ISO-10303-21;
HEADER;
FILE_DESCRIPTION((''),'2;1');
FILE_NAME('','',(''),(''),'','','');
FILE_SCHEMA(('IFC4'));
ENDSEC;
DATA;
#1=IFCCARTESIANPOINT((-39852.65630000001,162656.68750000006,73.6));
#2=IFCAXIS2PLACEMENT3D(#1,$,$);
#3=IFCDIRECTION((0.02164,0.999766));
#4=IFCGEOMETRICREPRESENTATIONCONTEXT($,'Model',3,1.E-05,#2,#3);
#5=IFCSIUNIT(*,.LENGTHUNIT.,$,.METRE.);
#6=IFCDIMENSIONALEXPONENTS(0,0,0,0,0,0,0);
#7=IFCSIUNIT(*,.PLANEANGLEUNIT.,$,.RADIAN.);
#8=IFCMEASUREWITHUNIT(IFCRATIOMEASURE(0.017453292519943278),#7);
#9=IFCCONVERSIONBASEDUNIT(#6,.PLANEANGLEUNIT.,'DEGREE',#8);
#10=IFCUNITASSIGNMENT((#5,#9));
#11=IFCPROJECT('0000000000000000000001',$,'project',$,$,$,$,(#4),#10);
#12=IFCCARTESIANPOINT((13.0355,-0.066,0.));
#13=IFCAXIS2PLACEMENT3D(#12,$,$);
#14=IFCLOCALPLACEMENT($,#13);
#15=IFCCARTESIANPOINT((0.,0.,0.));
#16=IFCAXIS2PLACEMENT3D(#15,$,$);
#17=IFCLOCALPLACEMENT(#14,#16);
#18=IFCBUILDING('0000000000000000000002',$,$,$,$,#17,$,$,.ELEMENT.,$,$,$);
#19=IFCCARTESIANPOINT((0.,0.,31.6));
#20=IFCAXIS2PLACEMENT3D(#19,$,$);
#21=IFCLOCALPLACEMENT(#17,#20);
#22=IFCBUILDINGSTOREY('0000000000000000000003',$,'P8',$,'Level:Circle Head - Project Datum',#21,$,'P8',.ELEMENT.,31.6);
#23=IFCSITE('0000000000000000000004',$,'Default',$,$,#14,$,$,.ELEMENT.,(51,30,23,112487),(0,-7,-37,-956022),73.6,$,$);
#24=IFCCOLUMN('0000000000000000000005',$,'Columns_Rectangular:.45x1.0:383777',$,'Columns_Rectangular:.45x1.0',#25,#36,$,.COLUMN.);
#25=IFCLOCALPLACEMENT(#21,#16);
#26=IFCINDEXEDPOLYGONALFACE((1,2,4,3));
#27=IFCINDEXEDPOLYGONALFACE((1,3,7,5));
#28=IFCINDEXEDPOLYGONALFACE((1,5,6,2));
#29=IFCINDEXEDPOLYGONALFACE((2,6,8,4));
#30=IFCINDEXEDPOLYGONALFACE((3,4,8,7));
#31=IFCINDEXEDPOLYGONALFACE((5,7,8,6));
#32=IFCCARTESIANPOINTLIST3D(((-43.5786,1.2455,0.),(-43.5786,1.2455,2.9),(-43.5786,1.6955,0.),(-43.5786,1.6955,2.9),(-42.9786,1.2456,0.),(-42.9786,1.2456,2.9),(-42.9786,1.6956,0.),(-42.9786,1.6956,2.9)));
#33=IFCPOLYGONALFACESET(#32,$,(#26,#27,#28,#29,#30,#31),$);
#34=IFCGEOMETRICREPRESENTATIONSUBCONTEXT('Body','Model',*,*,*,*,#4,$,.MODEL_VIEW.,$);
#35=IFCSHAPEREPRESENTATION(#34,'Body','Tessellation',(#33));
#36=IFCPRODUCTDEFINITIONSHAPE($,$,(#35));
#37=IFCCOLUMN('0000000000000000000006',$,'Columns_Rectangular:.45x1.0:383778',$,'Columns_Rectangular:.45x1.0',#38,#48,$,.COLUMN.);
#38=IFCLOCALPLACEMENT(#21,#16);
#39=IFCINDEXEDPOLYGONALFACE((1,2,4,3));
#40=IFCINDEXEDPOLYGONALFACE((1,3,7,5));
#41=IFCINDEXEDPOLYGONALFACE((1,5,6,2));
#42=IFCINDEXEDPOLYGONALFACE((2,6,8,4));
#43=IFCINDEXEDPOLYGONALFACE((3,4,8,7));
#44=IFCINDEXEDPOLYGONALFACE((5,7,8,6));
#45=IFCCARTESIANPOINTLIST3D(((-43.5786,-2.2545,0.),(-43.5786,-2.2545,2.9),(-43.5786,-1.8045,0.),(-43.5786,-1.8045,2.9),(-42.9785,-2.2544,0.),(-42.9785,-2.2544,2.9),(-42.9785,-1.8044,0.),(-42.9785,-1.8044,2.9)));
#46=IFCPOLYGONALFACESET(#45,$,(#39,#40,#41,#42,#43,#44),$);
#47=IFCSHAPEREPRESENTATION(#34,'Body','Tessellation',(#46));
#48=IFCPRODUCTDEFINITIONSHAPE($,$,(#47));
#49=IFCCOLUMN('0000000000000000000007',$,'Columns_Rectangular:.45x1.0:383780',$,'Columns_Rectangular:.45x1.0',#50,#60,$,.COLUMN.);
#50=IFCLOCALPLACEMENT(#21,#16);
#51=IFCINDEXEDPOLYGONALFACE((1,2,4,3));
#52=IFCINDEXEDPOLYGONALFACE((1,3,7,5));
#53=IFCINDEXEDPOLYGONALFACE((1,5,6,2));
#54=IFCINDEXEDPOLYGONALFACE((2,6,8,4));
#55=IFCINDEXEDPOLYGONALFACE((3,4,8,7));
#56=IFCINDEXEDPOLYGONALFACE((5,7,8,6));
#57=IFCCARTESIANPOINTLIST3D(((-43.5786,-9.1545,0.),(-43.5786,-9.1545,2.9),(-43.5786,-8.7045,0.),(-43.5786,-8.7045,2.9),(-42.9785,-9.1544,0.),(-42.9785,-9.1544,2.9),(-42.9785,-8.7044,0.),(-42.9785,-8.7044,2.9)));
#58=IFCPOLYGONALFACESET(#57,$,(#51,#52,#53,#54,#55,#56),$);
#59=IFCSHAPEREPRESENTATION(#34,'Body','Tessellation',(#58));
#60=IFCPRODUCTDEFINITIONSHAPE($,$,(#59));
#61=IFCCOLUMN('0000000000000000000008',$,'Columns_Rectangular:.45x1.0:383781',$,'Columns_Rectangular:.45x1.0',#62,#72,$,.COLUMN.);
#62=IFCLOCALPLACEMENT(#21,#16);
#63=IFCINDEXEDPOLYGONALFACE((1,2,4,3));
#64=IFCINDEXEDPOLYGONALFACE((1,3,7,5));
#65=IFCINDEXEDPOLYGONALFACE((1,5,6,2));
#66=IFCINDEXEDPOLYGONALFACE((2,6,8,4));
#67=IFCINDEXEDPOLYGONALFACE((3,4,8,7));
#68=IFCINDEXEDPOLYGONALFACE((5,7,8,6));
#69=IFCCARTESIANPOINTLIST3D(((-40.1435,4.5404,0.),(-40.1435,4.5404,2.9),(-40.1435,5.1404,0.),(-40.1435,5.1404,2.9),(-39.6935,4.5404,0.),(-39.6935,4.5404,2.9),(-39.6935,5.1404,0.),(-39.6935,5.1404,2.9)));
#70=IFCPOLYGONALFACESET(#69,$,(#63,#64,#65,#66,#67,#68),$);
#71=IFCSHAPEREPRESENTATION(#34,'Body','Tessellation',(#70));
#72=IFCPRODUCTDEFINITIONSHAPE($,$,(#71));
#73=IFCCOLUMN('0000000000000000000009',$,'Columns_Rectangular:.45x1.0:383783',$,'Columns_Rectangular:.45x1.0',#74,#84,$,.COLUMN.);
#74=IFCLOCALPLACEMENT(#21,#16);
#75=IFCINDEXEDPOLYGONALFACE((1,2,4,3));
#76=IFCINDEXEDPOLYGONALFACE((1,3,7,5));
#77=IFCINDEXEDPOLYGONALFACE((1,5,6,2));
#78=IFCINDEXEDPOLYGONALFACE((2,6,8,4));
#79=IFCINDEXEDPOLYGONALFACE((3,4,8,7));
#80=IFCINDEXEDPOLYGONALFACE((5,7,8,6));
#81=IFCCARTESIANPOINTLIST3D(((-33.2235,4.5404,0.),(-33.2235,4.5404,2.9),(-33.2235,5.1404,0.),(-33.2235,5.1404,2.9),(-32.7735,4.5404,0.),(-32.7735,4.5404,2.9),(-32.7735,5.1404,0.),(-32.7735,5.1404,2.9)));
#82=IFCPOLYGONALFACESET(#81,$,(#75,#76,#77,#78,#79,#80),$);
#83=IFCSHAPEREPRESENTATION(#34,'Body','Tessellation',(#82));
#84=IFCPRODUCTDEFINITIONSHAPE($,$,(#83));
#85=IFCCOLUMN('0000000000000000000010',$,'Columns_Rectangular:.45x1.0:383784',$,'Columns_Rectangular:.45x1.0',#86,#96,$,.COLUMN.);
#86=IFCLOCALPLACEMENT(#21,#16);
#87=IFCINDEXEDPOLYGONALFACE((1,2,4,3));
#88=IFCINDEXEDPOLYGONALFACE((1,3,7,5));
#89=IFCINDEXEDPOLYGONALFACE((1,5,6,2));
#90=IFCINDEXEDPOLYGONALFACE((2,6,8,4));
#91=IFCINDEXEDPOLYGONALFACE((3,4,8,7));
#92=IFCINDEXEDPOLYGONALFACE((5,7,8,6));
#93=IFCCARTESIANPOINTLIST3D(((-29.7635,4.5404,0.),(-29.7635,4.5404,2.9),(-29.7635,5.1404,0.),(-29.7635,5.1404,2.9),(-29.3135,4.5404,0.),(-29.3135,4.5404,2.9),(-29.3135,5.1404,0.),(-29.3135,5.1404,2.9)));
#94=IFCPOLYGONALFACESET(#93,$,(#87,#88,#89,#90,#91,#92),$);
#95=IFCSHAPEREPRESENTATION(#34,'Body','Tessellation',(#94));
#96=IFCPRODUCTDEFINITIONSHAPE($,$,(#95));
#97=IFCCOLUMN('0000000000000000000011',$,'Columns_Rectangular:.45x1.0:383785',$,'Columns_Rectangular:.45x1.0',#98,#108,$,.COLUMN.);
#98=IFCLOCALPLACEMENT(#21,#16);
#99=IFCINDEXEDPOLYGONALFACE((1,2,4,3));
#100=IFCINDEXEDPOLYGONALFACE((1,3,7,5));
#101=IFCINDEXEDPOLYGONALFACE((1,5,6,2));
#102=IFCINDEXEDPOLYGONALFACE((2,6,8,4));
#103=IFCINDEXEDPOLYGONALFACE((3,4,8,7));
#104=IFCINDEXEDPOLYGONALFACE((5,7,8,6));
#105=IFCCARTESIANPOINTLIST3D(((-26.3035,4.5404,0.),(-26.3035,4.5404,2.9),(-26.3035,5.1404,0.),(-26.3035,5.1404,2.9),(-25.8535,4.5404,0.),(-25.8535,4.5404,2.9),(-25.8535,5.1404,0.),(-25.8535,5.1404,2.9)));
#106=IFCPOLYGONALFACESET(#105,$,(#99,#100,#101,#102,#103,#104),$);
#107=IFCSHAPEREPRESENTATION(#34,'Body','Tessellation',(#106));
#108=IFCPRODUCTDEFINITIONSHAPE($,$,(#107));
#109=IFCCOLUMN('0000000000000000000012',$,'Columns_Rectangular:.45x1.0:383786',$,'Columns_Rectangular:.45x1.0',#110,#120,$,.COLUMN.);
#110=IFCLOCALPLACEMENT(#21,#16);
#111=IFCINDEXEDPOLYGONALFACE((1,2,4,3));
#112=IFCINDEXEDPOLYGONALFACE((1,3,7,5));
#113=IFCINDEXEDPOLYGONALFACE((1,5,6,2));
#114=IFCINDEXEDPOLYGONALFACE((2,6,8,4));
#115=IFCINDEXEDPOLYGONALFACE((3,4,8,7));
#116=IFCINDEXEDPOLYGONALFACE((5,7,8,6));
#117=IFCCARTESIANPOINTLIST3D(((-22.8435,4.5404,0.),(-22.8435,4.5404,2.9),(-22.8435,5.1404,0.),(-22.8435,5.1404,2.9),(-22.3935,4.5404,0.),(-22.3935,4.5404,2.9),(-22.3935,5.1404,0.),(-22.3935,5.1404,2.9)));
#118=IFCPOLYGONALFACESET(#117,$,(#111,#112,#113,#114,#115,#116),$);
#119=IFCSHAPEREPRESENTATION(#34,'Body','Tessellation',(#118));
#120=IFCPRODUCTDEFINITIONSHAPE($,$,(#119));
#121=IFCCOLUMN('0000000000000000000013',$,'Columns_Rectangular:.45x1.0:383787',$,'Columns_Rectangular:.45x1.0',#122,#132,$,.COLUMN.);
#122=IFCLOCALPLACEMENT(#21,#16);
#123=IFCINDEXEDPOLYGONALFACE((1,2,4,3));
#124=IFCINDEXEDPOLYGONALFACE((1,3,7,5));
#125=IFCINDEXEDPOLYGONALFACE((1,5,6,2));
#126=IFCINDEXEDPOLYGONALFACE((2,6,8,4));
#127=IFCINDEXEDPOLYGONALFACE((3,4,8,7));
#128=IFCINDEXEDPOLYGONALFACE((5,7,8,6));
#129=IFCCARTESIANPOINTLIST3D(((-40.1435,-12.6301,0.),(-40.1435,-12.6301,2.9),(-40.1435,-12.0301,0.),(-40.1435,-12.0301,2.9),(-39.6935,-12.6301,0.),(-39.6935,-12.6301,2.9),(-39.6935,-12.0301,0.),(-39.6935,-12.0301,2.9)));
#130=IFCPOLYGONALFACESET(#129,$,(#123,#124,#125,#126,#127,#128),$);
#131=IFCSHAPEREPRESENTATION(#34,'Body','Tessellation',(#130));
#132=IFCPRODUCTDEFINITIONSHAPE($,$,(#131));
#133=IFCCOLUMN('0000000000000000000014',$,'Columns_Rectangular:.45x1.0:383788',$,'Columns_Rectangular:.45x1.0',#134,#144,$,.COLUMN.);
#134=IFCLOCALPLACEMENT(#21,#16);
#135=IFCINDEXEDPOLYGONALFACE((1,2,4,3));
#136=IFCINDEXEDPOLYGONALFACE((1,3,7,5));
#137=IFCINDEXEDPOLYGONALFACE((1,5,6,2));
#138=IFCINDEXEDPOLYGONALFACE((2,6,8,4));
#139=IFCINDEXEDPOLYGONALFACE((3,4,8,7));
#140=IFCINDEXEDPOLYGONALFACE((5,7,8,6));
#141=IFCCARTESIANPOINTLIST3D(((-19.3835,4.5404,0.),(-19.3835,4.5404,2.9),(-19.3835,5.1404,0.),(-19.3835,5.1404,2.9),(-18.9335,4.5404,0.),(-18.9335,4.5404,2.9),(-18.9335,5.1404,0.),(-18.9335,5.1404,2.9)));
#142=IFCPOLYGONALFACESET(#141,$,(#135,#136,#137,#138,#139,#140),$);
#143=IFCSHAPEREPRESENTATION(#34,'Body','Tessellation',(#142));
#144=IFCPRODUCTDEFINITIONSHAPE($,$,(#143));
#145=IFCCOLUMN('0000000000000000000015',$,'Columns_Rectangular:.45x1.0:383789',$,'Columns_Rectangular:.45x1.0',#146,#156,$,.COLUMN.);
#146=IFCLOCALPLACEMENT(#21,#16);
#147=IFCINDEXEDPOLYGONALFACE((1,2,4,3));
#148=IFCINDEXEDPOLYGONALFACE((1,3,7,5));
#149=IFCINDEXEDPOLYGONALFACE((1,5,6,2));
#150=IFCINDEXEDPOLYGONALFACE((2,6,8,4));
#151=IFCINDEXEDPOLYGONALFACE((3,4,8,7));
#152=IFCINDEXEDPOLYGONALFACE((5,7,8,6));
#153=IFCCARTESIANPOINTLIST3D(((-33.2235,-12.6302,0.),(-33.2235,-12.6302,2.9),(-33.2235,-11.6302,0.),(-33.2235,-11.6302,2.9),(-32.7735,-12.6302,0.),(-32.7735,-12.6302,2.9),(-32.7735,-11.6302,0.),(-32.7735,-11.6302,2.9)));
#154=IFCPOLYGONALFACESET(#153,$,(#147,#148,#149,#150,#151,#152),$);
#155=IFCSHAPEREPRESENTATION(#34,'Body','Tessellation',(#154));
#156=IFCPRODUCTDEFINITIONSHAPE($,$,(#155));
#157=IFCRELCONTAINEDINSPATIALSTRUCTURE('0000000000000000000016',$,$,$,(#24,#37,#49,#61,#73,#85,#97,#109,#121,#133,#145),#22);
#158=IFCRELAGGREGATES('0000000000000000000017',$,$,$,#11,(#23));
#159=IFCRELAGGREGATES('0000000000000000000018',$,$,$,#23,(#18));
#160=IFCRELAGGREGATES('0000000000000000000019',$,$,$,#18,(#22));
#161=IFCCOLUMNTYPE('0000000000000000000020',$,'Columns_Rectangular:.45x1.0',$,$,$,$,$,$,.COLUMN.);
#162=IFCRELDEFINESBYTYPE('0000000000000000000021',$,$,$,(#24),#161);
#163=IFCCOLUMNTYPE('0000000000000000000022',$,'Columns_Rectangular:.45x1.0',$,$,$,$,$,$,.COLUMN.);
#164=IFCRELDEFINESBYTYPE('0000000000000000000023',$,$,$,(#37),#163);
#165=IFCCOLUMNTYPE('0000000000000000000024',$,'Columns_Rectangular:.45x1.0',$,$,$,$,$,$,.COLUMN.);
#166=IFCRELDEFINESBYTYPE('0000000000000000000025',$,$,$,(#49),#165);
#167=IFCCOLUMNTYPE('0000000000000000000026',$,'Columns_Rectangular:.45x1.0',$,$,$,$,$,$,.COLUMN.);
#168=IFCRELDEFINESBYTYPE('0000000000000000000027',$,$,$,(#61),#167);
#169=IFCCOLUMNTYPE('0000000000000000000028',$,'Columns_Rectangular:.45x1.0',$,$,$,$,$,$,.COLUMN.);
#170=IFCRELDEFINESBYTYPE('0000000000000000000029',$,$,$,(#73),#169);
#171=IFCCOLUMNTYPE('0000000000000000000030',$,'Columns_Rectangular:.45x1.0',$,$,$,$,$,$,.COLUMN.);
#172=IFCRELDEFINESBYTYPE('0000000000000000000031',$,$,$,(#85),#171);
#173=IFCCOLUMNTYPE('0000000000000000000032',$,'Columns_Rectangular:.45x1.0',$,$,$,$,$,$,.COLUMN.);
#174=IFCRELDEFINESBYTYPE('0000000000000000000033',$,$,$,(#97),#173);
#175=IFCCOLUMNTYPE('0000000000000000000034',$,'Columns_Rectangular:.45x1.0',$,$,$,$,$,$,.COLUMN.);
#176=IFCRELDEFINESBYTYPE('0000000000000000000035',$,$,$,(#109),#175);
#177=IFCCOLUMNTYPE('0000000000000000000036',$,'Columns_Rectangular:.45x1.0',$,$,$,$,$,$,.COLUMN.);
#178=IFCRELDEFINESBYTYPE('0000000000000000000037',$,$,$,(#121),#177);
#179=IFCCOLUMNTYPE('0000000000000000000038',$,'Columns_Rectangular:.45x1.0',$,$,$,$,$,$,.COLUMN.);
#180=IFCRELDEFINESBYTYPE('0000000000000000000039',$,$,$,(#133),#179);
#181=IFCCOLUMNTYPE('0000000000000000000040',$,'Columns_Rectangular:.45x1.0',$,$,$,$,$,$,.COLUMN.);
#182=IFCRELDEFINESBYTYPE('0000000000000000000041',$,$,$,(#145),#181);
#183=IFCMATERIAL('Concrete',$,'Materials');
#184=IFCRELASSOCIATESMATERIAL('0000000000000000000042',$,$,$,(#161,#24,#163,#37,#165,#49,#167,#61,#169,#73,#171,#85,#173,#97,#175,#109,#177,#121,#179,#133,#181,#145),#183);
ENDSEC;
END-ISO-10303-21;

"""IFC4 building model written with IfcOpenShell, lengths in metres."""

from ifc_helpers import new_model, entity, si_unit, converted_unit, direction, frame, origin, place, context, subcontext, project, spatial, indexed_curve, outline, extrude, source, transform, mapped, material, type_object, type_shapes, element, save


model = new_model("IFC4")

# Units and contexts
model_context = context("Model", 3, precision=1e-05, world=frame((-39852.65630000001, 162656.68750000006, 73.6)), true_north=direction((0.02164, 0.999766)))
body_context = subcontext(model_context, "Body", "Model", "MODEL_VIEW")
ifc_project = project(units=[si_unit("LENGTHUNIT", "METRE"), converted_unit("PLANEANGLEUNIT", "DEGREE", entity("IfcRatioMeasure", 0.017453292519943278), si_unit("PLANEANGLEUNIT", "RADIAN"), dimensions=[0, 0, 0, 0, 0, 0, 0])], contexts=[model_context])

# Site, building, storey
site_placement = place(None, frame((13.0355, -0.066, 0.0)))
site = spatial("IfcSite", under=ifc_project, at=site_placement, Name="Default", CompositionType="ELEMENT", RefLatitude=(51, 30, 23, 112487), RefLongitude=(0, -7, -37, -956022), RefElevation=73.6)
building_placement = place(site_placement, origin())
building = spatial("IfcBuilding", under=site, at=building_placement, CompositionType="ELEMENT")
storey_placement = place(building_placement, frame((0.0, 0.0, 31.6)))
storey = spatial("IfcBuildingStorey", under=building, at=storey_placement, Name="P8", ObjectType="Level:Circle Head - Project Datum", LongName="P8", CompositionType="ELEMENT", Elevation=31.6)

# Columns
ifc_material = material(Name="Concrete", Category="Materials")
column_type_1 = type_object("IfcColumnType", Name="Columns_Rectangular:.45x1.0", PredefinedType="COLUMN", material=ifc_material)
shared_shape_1 = source(origin(), body_context, "Body", "SweptSolid", [
    extrude(outline(indexed_curve([(-0.3, -0.225), (0.3, -0.225), (0.3, 0.225), (-0.3, 0.225), (-0.3, -0.225)], self_intersect=False)), frame((-43.2786, 1.4706, 31.6), z_axis=(0.0, 0.0, 1.0), x_axis=(-1.0, -0.000005, 0.0)), (0.0, 0.0, 1.0), 2.9),
])
type_shapes(column_type_1, [shared_shape_1])
column_1_placement = place(storey_placement, frame((0.0, 0.0, -31.6)))
element("IfcColumn", 1, at=column_1_placement, inside=storey, type_object=column_type_1, material=ifc_material, Name="Columns_Rectangular:.45x1.0:383777", ObjectType="Columns_Rectangular:.45x1.0", PredefinedType="COLUMN", context=body_context, shape_type="MappedRepresentation", body=[
    mapped(shared_shape_1, transform((0.0, 0.0, 0.0), scale=1.0)),
])
column_type_2 = type_object("IfcColumnType", Name="Columns_Rectangular:.45x1.0", PredefinedType="COLUMN", material=ifc_material)
shared_shape_2 = source(origin(), body_context, "Body", "SweptSolid", [
    extrude(outline(indexed_curve([(-0.3, -0.225), (0.3, -0.225), (0.3, 0.225), (-0.3, 0.225), (-0.3, -0.225)], self_intersect=False)), frame((-43.2785, -2.0294, 31.6), z_axis=(0.0, 0.0, 1.0), x_axis=(-1.0, -0.000005, 0.0)), (0.0, 0.0, 1.0), 2.9),
])
type_shapes(column_type_2, [shared_shape_2])
column_2_placement = place(storey_placement, frame((0.0, 0.0, -31.6)))
element("IfcColumn", 2, at=column_2_placement, inside=storey, type_object=column_type_2, material=ifc_material, Name="Columns_Rectangular:.45x1.0:383778", ObjectType="Columns_Rectangular:.45x1.0", PredefinedType="COLUMN", context=body_context, shape_type="MappedRepresentation", body=[
    mapped(shared_shape_2, transform((0.0, 0.0, 0.0), scale=1.0)),
])
column_type_3 = type_object("IfcColumnType", Name="Columns_Rectangular:.45x1.0", PredefinedType="COLUMN", material=ifc_material)
shared_shape_3 = source(origin(), body_context, "Body", "SweptSolid", [
    extrude(outline(indexed_curve([(-0.3, -0.225), (0.3, -0.225), (0.3, 0.225), (-0.3, 0.225), (-0.3, -0.225)], self_intersect=False)), frame((-43.2785, -8.9294, 31.6), z_axis=(0.0, 0.0, 1.0), x_axis=(-1.0, -0.000005, 0.0)), (0.0, 0.0, 1.0), 2.9),
])
type_shapes(column_type_3, [shared_shape_3])
column_3_placement = place(storey_placement, frame((0.0, 0.0, -31.6)))
element("IfcColumn", 3, at=column_3_placement, inside=storey, type_object=column_type_3, material=ifc_material, Name="Columns_Rectangular:.45x1.0:383780", ObjectType="Columns_Rectangular:.45x1.0", PredefinedType="COLUMN", context=body_context, shape_type="MappedRepresentation", body=[
    mapped(shared_shape_3, transform((0.0, 0.0, 0.0), scale=1.0)),
])
column_type_4 = type_object("IfcColumnType", Name="Columns_Rectangular:.45x1.0", PredefinedType="COLUMN", material=ifc_material)
shared_shape_4 = source(origin(), body_context, "Body", "SweptSolid", [
    extrude(outline(indexed_curve([(-0.3, -0.225), (0.3, -0.225), (0.3, 0.225), (-0.3, 0.225), (-0.3, -0.225)], self_intersect=False)), frame((-39.9185, 4.8404, 31.6), z_axis=(0.0, 0.0, 1.0), x_axis=(0.0, -1.0, 0.0)), (0.0, 0.0, 1.0), 2.9),
])
type_shapes(column_type_4, [shared_shape_4])
column_4_placement = place(storey_placement, frame((0.0, 0.0, -31.6)))
element("IfcColumn", 4, at=column_4_placement, inside=storey, type_object=column_type_4, material=ifc_material, Name="Columns_Rectangular:.45x1.0:383781", ObjectType="Columns_Rectangular:.45x1.0", PredefinedType="COLUMN", context=body_context, shape_type="MappedRepresentation", body=[
    mapped(shared_shape_4, transform((0.0, 0.0, 0.0), scale=1.0)),
])
column_type_5 = type_object("IfcColumnType", Name="Columns_Rectangular:.45x1.0", PredefinedType="COLUMN", material=ifc_material)
shared_shape_5 = source(origin(), body_context, "Body", "SweptSolid", [
    extrude(outline(indexed_curve([(-0.3, -0.225), (0.3, -0.225), (0.3, 0.225), (-0.3, 0.225), (-0.3, -0.225)], self_intersect=False)), frame((-32.9985, 4.8404, 31.6), z_axis=(0.0, 0.0, 1.0), x_axis=(0.0, -1.0, 0.0)), (0.0, 0.0, 1.0), 2.9),
])
type_shapes(column_type_5, [shared_shape_5])
column_5_placement = place(storey_placement, frame((0.0, 0.0, -31.6)))
element("IfcColumn", 5, at=column_5_placement, inside=storey, type_object=column_type_5, material=ifc_material, Name="Columns_Rectangular:.45x1.0:383783", ObjectType="Columns_Rectangular:.45x1.0", PredefinedType="COLUMN", context=body_context, shape_type="MappedRepresentation", body=[
    mapped(shared_shape_5, transform((0.0, 0.0, 0.0), scale=1.0)),
])
column_type_6 = type_object("IfcColumnType", Name="Columns_Rectangular:.45x1.0", PredefinedType="COLUMN", material=ifc_material)
shared_shape_6 = source(origin(), body_context, "Body", "SweptSolid", [
    extrude(outline(indexed_curve([(-0.3, -0.225), (0.3, -0.225), (0.3, 0.225), (-0.3, 0.225), (-0.3, -0.225)], self_intersect=False)), frame((-29.5385, 4.8404, 31.6), z_axis=(0.0, 0.0, 1.0), x_axis=(0.0, -1.0, 0.0)), (0.0, 0.0, 1.0), 2.9),
])
type_shapes(column_type_6, [shared_shape_6])
column_6_placement = place(storey_placement, frame((0.0, 0.0, -31.6)))
element("IfcColumn", 6, at=column_6_placement, inside=storey, type_object=column_type_6, material=ifc_material, Name="Columns_Rectangular:.45x1.0:383784", ObjectType="Columns_Rectangular:.45x1.0", PredefinedType="COLUMN", context=body_context, shape_type="MappedRepresentation", body=[
    mapped(shared_shape_6, transform((0.0, 0.0, 0.0), scale=1.0)),
])
column_type_7 = type_object("IfcColumnType", Name="Columns_Rectangular:.45x1.0", PredefinedType="COLUMN", material=ifc_material)
shared_shape_7 = source(origin(), body_context, "Body", "SweptSolid", [
    extrude(outline(indexed_curve([(-0.3, -0.225), (0.3, -0.225), (0.3, 0.225), (-0.3, 0.225), (-0.3, -0.225)], self_intersect=False)), frame((-26.0785, 4.8404, 31.6), z_axis=(0.0, 0.0, 1.0), x_axis=(0.0, -1.0, 0.0)), (0.0, 0.0, 1.0), 2.9),
])
type_shapes(column_type_7, [shared_shape_7])
column_7_placement = place(storey_placement, frame((0.0, 0.0, -31.6)))
element("IfcColumn", 7, at=column_7_placement, inside=storey, type_object=column_type_7, material=ifc_material, Name="Columns_Rectangular:.45x1.0:383785", ObjectType="Columns_Rectangular:.45x1.0", PredefinedType="COLUMN", context=body_context, shape_type="MappedRepresentation", body=[
    mapped(shared_shape_7, transform((0.0, 0.0, 0.0), scale=1.0)),
])
column_type_8 = type_object("IfcColumnType", Name="Columns_Rectangular:.45x1.0", PredefinedType="COLUMN", material=ifc_material)
shared_shape_8 = source(origin(), body_context, "Body", "SweptSolid", [
    extrude(outline(indexed_curve([(-0.3, -0.225), (0.3, -0.225), (0.3, 0.225), (-0.3, 0.225), (-0.3, -0.225)], self_intersect=False)), frame((-22.6185, 4.8404, 31.6), z_axis=(0.0, 0.0, 1.0), x_axis=(0.0, -1.0, 0.0)), (0.0, 0.0, 1.0), 2.9),
])
type_shapes(column_type_8, [shared_shape_8])
column_8_placement = place(storey_placement, frame((0.0, 0.0, -31.6)))
element("IfcColumn", 8, at=column_8_placement, inside=storey, type_object=column_type_8, material=ifc_material, Name="Columns_Rectangular:.45x1.0:383786", ObjectType="Columns_Rectangular:.45x1.0", PredefinedType="COLUMN", context=body_context, shape_type="MappedRepresentation", body=[
    mapped(shared_shape_8, transform((0.0, 0.0, 0.0), scale=1.0)),
])
column_type_9 = type_object("IfcColumnType", Name="Columns_Rectangular:.45x1.0", PredefinedType="COLUMN", material=ifc_material)
shared_shape_9 = source(origin(), body_context, "Body", "SweptSolid", [
    extrude(outline(indexed_curve([(-0.3, -0.225), (0.3, -0.225), (0.3, 0.225), (-0.3, 0.225), (-0.3, -0.225)], self_intersect=False)), frame((-39.9185, -12.3301, 31.6), z_axis=(0.0, 0.0, 1.0), x_axis=(0.000011, 1.0, 0.0)), (0.0, 0.0, 1.0), 2.9),
])
type_shapes(column_type_9, [shared_shape_9])
column_9_placement = place(storey_placement, frame((0.0, 0.0, -31.6)))
element("IfcColumn", 9, at=column_9_placement, inside=storey, type_object=column_type_9, material=ifc_material, Name="Columns_Rectangular:.45x1.0:383787", ObjectType="Columns_Rectangular:.45x1.0", PredefinedType="COLUMN", context=body_context, shape_type="MappedRepresentation", body=[
    mapped(shared_shape_9, transform((0.0, 0.0, 0.0), scale=1.0)),
])
column_type_10 = type_object("IfcColumnType", Name="Columns_Rectangular:.45x1.0", PredefinedType="COLUMN", material=ifc_material)
shared_shape_10 = source(origin(), body_context, "Body", "SweptSolid", [
    extrude(outline(indexed_curve([(-0.3, -0.225), (0.3, -0.225), (0.3, 0.225), (-0.3, 0.225), (-0.3, -0.225)], self_intersect=False)), frame((-19.1585, 4.8404, 31.6), z_axis=(0.0, 0.0, 1.0), x_axis=(0.0, -1.0, 0.0)), (0.0, 0.0, 1.0), 2.9),
])
type_shapes(column_type_10, [shared_shape_10])
column_10_placement = place(storey_placement, frame((0.0, 0.0, -31.6)))
element("IfcColumn", 10, at=column_10_placement, inside=storey, type_object=column_type_10, material=ifc_material, Name="Columns_Rectangular:.45x1.0:383788", ObjectType="Columns_Rectangular:.45x1.0", PredefinedType="COLUMN", context=body_context, shape_type="MappedRepresentation", body=[
    mapped(shared_shape_10, transform((0.0, 0.0, 0.0), scale=1.0)),
])
column_type_11 = type_object("IfcColumnType", Name="Columns_Rectangular:.45x1.0", PredefinedType="COLUMN", material=ifc_material)
shared_shape_11 = source(origin(), body_context, "Body", "SweptSolid", [
    extrude(outline(indexed_curve([(-0.5, -0.225), (0.5, -0.225), (0.5, 0.225), (-0.5, 0.225), (-0.5, -0.225)], self_intersect=False)), frame((-32.9985, -12.1302, 31.6), z_axis=(0.0, 0.0, 1.0), x_axis=(0.000011, 1.0, 0.0)), (0.0, 0.0, 1.0), 2.9),
])
type_shapes(column_type_11, [shared_shape_11])
column_11_placement = place(storey_placement, frame((0.0, 0.0, -31.6)))
element("IfcColumn", 11, at=column_11_placement, inside=storey, type_object=column_type_11, material=ifc_material, Name="Columns_Rectangular:.45x1.0:383789", ObjectType="Columns_Rectangular:.45x1.0", PredefinedType="COLUMN", context=body_context, shape_type="MappedRepresentation", body=[
    mapped(shared_shape_11, transform((0.0, 0.0, 0.0), scale=1.0)),
])

save(model, "model.ifc")
